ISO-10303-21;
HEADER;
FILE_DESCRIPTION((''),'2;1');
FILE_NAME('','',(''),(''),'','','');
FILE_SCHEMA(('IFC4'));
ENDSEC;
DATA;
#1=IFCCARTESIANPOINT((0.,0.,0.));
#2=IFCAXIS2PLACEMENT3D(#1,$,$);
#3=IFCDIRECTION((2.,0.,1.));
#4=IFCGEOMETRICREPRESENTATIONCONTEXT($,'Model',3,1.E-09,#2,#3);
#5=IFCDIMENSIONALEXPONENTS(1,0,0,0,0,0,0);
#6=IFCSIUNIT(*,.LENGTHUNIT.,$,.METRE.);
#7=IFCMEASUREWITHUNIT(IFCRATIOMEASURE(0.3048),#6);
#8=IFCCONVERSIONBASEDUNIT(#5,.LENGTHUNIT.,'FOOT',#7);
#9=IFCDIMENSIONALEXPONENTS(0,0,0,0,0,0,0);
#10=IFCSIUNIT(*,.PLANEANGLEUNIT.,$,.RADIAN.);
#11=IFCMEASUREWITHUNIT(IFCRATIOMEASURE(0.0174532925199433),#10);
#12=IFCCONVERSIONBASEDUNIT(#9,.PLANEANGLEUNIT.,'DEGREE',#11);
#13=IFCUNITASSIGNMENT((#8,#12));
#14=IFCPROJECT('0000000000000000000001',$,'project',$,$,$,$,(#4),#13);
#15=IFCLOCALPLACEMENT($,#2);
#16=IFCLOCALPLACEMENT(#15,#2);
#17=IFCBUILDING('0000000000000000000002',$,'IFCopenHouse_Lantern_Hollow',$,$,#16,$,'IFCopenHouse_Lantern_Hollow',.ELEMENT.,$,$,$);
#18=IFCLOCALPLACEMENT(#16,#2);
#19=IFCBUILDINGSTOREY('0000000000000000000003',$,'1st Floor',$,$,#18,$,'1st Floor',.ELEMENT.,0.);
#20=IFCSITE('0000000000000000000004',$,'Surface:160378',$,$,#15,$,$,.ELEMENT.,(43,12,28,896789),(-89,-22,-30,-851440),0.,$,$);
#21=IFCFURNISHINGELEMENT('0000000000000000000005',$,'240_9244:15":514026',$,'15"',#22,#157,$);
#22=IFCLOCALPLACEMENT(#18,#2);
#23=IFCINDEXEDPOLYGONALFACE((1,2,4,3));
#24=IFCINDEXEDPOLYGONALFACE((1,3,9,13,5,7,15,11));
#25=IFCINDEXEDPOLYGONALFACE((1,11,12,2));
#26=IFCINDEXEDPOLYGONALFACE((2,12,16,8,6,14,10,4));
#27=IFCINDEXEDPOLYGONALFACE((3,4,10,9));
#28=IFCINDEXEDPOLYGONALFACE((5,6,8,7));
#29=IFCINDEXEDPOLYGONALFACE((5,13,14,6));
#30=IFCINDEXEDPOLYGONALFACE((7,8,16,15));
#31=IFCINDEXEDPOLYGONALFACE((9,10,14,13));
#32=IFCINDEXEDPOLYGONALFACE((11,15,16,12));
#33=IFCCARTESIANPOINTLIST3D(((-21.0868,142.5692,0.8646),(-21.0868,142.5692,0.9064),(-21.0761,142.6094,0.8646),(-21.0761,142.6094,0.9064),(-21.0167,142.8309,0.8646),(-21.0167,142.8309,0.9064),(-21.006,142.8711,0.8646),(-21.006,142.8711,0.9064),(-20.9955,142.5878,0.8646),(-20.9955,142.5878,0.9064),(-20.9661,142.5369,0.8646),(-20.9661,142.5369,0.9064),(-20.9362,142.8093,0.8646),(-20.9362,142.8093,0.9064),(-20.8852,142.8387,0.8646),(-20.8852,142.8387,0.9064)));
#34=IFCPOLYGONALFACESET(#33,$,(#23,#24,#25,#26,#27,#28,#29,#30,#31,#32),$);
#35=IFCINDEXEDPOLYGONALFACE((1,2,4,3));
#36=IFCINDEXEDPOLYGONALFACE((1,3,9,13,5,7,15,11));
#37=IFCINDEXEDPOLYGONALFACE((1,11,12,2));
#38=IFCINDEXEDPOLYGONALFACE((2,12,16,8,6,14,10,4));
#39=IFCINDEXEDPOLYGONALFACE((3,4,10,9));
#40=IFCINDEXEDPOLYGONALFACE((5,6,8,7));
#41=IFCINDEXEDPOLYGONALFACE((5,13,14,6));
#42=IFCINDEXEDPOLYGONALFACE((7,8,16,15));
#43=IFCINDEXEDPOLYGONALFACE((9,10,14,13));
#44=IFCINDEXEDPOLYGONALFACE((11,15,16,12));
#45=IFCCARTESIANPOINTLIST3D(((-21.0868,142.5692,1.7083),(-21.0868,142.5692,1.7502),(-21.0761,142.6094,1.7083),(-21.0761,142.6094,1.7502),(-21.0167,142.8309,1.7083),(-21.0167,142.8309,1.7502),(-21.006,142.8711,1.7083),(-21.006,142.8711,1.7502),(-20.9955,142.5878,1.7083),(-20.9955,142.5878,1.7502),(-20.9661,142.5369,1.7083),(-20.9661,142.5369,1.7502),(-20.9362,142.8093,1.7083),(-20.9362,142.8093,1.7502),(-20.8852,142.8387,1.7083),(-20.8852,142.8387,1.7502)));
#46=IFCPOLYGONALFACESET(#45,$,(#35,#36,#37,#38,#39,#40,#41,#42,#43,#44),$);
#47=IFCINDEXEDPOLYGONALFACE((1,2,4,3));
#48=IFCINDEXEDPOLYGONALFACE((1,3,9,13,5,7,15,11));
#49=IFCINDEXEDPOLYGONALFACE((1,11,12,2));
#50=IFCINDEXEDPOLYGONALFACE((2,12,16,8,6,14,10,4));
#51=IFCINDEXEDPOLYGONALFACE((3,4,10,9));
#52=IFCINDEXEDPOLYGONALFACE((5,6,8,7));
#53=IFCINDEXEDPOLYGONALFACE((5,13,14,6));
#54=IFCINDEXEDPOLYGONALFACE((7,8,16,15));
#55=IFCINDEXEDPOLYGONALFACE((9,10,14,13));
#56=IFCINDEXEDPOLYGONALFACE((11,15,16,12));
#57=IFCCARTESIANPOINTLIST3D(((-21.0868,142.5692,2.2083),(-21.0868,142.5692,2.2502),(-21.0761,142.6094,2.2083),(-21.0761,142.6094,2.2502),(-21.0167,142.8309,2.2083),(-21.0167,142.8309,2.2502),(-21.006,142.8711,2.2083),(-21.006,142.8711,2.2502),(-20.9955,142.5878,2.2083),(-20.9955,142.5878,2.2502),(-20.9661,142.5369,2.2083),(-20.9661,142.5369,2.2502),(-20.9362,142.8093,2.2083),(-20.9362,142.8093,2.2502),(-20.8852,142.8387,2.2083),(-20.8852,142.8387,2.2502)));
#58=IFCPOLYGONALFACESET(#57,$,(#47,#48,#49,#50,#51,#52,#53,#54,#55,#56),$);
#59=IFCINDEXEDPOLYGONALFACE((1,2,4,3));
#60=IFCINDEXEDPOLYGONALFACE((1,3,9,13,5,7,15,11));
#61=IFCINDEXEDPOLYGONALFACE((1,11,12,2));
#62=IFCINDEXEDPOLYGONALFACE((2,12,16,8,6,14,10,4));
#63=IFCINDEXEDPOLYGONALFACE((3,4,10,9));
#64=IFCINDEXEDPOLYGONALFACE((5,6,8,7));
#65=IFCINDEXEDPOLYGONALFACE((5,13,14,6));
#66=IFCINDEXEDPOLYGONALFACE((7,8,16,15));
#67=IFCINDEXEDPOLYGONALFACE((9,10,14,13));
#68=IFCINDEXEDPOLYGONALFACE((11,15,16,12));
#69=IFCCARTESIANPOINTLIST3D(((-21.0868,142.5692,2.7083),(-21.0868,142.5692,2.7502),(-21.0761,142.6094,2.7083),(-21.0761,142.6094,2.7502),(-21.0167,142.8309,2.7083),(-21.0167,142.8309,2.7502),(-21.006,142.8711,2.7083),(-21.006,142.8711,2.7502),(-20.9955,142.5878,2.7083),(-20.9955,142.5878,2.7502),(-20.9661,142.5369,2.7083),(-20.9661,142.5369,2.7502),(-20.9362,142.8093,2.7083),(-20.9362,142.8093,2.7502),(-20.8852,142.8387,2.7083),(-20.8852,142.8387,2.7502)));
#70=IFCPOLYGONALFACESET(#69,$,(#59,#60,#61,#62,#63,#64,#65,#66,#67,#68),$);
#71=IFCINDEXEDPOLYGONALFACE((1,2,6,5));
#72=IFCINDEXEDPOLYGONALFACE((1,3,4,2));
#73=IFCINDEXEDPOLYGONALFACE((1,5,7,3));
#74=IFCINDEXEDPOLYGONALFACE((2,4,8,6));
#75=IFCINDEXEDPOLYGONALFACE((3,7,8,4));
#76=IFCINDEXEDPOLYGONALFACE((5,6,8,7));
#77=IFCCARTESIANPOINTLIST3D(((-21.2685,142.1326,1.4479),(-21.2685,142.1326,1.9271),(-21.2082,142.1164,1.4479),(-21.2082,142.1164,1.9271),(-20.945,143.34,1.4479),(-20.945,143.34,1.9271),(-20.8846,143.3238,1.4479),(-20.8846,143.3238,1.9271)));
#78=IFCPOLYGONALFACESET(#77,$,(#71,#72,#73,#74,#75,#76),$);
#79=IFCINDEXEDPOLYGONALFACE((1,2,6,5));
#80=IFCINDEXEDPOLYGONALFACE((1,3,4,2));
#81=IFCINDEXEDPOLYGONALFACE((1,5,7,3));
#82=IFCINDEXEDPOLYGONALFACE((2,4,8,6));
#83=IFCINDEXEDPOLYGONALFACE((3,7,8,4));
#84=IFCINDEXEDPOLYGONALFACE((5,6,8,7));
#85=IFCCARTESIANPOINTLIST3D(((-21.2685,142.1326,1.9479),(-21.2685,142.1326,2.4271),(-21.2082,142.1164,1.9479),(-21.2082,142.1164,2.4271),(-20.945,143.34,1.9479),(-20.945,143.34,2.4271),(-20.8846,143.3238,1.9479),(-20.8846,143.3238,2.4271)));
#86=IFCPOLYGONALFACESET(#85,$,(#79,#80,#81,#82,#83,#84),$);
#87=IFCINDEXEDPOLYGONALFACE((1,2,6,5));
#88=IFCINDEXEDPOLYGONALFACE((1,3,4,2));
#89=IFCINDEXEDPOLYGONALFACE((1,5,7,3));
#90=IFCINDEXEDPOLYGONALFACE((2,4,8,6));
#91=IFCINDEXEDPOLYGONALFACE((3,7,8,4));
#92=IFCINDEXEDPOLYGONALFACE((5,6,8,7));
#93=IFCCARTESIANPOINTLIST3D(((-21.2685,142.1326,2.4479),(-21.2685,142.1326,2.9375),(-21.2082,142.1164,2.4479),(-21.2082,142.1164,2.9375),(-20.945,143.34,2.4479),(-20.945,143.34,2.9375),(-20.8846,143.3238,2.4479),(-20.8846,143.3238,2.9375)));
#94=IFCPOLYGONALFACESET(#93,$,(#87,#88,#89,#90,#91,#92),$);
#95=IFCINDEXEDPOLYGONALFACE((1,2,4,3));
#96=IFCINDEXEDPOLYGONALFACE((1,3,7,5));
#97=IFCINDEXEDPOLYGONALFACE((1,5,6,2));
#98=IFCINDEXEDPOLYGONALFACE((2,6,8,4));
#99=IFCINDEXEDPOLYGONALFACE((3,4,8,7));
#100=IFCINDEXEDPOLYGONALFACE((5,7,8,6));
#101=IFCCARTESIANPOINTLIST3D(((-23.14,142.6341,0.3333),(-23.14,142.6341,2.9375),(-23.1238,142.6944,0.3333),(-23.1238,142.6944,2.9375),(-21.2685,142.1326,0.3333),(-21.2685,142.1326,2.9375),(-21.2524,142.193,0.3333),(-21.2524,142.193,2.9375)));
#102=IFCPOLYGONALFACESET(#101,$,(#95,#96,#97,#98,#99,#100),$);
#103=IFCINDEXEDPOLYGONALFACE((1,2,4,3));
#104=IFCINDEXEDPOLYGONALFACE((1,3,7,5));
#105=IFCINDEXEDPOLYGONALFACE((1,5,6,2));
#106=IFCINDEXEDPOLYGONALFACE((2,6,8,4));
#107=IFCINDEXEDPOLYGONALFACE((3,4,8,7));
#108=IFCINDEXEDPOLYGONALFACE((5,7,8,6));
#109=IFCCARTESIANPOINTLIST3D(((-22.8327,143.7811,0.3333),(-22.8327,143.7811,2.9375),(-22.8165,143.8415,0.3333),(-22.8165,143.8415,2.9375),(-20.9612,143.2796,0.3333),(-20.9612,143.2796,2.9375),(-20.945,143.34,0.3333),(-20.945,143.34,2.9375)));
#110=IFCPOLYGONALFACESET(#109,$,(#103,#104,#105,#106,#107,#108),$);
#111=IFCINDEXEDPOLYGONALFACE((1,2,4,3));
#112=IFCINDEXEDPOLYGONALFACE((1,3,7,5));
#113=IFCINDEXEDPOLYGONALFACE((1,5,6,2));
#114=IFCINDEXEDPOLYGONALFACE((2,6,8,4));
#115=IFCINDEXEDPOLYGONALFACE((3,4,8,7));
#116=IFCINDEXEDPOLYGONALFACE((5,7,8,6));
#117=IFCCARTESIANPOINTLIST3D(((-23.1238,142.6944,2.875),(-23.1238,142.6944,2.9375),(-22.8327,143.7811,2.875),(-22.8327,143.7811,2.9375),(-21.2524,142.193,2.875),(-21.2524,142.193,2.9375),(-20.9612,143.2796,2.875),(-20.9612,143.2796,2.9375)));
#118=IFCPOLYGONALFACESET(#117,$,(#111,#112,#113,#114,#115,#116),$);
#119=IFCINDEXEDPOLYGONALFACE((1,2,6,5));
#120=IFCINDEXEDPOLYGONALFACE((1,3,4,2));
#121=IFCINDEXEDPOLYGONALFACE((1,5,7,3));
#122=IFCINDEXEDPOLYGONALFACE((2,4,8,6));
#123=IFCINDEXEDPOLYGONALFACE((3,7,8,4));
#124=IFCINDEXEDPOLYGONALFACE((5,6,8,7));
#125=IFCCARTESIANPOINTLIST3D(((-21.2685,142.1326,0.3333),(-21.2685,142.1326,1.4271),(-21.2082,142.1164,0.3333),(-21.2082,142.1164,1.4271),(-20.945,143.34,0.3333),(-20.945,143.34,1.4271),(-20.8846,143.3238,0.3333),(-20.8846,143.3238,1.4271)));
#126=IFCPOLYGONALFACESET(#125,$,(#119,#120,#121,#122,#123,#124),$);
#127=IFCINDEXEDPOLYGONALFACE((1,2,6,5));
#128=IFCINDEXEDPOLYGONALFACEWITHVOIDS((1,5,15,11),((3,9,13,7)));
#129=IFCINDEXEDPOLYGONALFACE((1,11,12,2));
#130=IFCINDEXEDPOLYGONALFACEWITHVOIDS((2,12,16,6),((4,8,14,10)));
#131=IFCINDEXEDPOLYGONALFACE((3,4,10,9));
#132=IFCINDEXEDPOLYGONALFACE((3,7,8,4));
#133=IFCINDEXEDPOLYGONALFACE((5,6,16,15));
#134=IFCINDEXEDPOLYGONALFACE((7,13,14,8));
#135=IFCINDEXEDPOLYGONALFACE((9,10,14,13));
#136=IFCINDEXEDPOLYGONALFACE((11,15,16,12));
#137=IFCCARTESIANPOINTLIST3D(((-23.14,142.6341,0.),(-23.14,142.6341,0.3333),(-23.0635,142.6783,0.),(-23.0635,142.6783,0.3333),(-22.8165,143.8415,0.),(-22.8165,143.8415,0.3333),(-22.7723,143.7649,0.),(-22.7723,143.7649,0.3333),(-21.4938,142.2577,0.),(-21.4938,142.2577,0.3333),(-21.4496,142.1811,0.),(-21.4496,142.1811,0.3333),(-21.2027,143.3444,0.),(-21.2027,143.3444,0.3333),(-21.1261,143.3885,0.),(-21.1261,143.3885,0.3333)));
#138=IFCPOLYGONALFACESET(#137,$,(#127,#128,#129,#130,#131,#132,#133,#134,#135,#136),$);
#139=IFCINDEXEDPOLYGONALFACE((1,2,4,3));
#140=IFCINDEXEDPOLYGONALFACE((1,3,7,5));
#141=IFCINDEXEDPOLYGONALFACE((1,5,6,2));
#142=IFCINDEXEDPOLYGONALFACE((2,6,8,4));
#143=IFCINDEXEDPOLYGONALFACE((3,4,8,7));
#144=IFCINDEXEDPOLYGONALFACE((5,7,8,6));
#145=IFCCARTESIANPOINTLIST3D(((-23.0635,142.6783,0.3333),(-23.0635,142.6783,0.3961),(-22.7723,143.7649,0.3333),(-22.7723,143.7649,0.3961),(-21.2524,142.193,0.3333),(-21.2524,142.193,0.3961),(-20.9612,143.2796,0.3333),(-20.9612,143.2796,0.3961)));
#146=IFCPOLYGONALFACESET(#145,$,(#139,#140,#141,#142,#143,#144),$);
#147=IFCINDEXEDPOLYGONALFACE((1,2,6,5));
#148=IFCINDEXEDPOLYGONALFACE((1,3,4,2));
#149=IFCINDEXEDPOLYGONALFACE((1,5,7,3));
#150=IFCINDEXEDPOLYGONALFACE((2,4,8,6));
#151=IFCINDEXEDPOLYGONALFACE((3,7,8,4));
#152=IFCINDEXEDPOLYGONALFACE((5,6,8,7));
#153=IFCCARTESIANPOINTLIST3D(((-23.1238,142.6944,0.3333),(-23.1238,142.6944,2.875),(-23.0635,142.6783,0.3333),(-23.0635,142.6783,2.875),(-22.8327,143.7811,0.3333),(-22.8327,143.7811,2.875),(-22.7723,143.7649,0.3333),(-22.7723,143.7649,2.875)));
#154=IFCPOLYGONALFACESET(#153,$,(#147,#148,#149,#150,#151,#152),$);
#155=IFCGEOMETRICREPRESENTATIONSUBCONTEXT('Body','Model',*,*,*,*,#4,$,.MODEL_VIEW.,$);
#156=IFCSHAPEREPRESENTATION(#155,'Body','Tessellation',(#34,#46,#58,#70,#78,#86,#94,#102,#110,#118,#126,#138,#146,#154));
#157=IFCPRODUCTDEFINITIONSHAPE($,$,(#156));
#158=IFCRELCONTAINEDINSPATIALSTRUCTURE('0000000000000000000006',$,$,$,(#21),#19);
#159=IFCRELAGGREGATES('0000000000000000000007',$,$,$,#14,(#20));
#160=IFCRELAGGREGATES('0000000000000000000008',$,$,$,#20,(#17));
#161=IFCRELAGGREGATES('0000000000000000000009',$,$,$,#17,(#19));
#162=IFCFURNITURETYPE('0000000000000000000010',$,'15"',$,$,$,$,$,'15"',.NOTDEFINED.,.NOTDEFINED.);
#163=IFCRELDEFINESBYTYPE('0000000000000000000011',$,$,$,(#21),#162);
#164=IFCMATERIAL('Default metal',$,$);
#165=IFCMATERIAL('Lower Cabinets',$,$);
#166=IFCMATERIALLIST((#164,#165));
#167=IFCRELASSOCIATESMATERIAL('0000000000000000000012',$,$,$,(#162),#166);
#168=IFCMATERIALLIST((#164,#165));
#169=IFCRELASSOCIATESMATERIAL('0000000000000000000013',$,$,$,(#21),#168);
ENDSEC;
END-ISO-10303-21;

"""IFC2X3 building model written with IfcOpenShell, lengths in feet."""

from ifc_helpers import new_model, entity, si_unit, converted_unit, direction, frame, frame_2d, origin, origin_2d_with_axis, place, context, subcontext, project, spatial, polyline, rectangle, outline, extrude, source, transform, mapped, material, material_list, type_object, type_shapes, element, save


model = new_model("IFC2X3")

# Units and contexts
model_context = context("Model", 3, precision=1e-09, world=origin(), true_north=direction((2.0, 0.0, 1.0)))
body_context = subcontext(model_context, "Body", "Model", "MODEL_VIEW")
ifc_project = project(units=[converted_unit("LENGTHUNIT", "FOOT", entity("IfcRatioMeasure", 0.3048), si_unit("LENGTHUNIT", "METRE"), dimensions=[1, 0, 0, 0, 0, 0, 0]), converted_unit("PLANEANGLEUNIT", "DEGREE", entity("IfcRatioMeasure", 0.0174532925199433), si_unit("PLANEANGLEUNIT", "RADIAN"), dimensions=[0, 0, 0, 0, 0, 0, 0])], contexts=[model_context])

# Site, building, storey
site_placement = place(None, origin())
site = spatial("IfcSite", under=ifc_project, at=site_placement, Name="Surface:160378", CompositionType="ELEMENT", RefLatitude=(43, 12, 28, 896789), RefLongitude=(-89, -22, -30, -851440), RefElevation=0.0)
building_placement = place(site_placement, origin())
building = spatial("IfcBuilding", under=site, at=building_placement, Name="IFCopenHouse_Lantern_Hollow", LongName="IFCopenHouse_Lantern_Hollow", CompositionType="ELEMENT")
storey_placement = place(building_placement, origin())
storey = spatial("IfcBuildingStorey", under=building, at=storey_placement, Name="1st Floor", LongName="1st Floor", CompositionType="ELEMENT", Elevation=0.0)

# Furnishing element
ifc_material_1 = material(Name="Default metal")
ifc_material_2 = material(Name="Lower Cabinets")
ifc_material_list_1 = material_list([ifc_material_1, ifc_material_2])
ifc_material_list_2 = material_list([ifc_material_1, ifc_material_2])
furniture_type_1 = type_object("IfcFurnitureType", Name="15\"", ElementType="15\"", AssemblyPlace="NOTDEFINED", material=ifc_material_list_2)
shared_shape_1 = source(origin(), body_context, "Body", "SweptSolid", [
    extrude(outline(polyline([(-0.0521, -0.1562), (0.0729, -0.1562), (0.0729, 0.1562), (-0.0521, 0.1562), (-0.0521, 0.1146), (0.0313, 0.1146), (0.0313, -0.1146), (-0.0521, -0.1146), (-0.0521, -0.1562)])), frame((0.625, 0.0729, 0.8646), z_axis=(0.0, 0.0, 1.0), x_axis=(0.0, -1.0, 0.0)), (0.0, 0.0, 1.0), 0.0418),
    extrude(outline(polyline([(-0.0521, -0.1562), (0.0729, -0.1562), (0.0729, 0.1562), (-0.0521, 0.1562), (-0.0521, 0.1146), (0.0313, 0.1146), (0.0313, -0.1146), (-0.0521, -0.1146), (-0.0521, -0.1562)])), frame((0.625, 0.0729, 1.7083), z_axis=(0.0, 0.0, 1.0), x_axis=(0.0, -1.0, 0.0)), (0.0, 0.0, 1.0), 0.0418),
    extrude(outline(polyline([(-0.0521, -0.1562), (0.0729, -0.1562), (0.0729, 0.1562), (-0.0521, 0.1562), (-0.0521, 0.1146), (0.0313, 0.1146), (0.0313, -0.1146), (-0.0521, -0.1146), (-0.0521, -0.1562)])), frame((0.625, 0.0729, 2.2083), z_axis=(0.0, 0.0, 1.0), x_axis=(0.0, -1.0, 0.0)), (0.0, 0.0, 1.0), 0.0418),
    extrude(outline(polyline([(-0.0521, -0.1562), (0.0729, -0.1562), (0.0729, 0.1562), (-0.0521, 0.1562), (-0.0521, 0.1146), (0.0313, 0.1146), (0.0313, -0.1146), (-0.0521, -0.1146), (-0.0521, -0.1562)])), frame((0.625, 0.0729, 2.7083), z_axis=(0.0, 0.0, 1.0), x_axis=(0.0, -1.0, 0.0)), (0.0, 0.0, 1.0), 0.0418),
    extrude(rectangle(XDim=0.0625, YDim=1.25, at=frame_2d((0.0, 0.0), x_axis=(1.0, 0.0))), frame((0.625, 0.1562, 1.4479), z_axis=(0.0, 0.0, 1.0), x_axis=(0.0, 1.0, 0.0)), (0.0, 0.0, 1.0), 0.4792),
    extrude(rectangle(XDim=0.0625, YDim=1.25, at=frame_2d((0.0, 0.0), x_axis=(1.0, 0.0))), frame((0.625, 0.1562, 1.9479), z_axis=(0.0, 0.0, 1.0), x_axis=(0.0, 1.0, 0.0)), (0.0, 0.0, 1.0), 0.4792),
    extrude(rectangle(XDim=0.0625, YDim=1.25, at=frame_2d((0.0, 0.0), x_axis=(1.0, 0.0))), frame((0.625, 0.1562, 2.4479), z_axis=(0.0, 0.0, 1.0), x_axis=(0.0, 1.0, 0.0)), (0.0, 0.0, 1.0), 0.4896),
    extrude(rectangle(XDim=0.0625, YDim=1.9375, at=frame_2d((0.0, 0.0), x_axis=(1.0, 0.0))), frame((0.0313, 1.1562, 0.3333)), (0.0, 0.0, 1.0), 2.6042),
    extrude(rectangle(XDim=0.0625, YDim=1.9375, at=frame_2d((0.0, 0.0), x_axis=(1.0, 0.0))), frame((1.2188, 1.1562, 0.3333)), (0.0, 0.0, 1.0), 2.6042),
    extrude(rectangle(XDim=1.125, YDim=1.9375, at=origin_2d_with_axis()), frame((0.625, 1.1562, 2.875), z_axis=(0.0, 0.0, 1.0), x_axis=(-1.0, 0.0, 0.0)), (0.0, 0.0, 1.0), 0.0625),
    extrude(rectangle(XDim=0.0625, YDim=1.25, at=frame_2d((0.0, 0.0), x_axis=(1.0, 0.0))), frame((0.625, 0.1562, 0.3333), z_axis=(0.0, 0.0, 1.0), x_axis=(0.0, 1.0, 0.0)), (0.0, 0.0, 1.0), 1.0937),
    extrude(outline(polyline([(-0.625, -0.875), (0.625, -0.875), (0.625, 0.875), (-0.625, 0.875), (-0.625, -0.875)]), holes=[polyline([(-0.5625, -0.8125), (-0.5625, 0.8125), (0.5625, 0.8125), (0.5625, -0.8125), (-0.5625, -0.8125)])]), frame((0.625, 1.25, 0.0)), (0.0, 0.0, 1.0), 0.3333),
    extrude(rectangle(XDim=1.125, YDim=1.875, at=frame_2d((0.0, 0.0), x_axis=(1.0, 0.0))), frame((0.625, 1.125, 0.3333), z_axis=(0.0, 0.0, 1.0), x_axis=(-1.0, 0.0, 0.0)), (0.0, 0.0, 1.0), 0.0627),
    extrude(rectangle(XDim=0.0625, YDim=1.125, at=origin_2d_with_axis()), frame((0.625, 2.0938, 0.3333), z_axis=(0.0, 0.0, 1.0), x_axis=(0.0, 1.0, 0.0)), (0.0, 0.0, 1.0), 2.5417),
])
type_shapes(furniture_type_1, [shared_shape_1])
furnishing_1_placement = place(storey_placement, frame((-21.0874, 142.0841, 0.0), z_axis=(0.0, 0.0, 1.0), x_axis=(0.258819, 0.965926, 0.0)))
element("IfcFurnishingElement", 1, at=furnishing_1_placement, inside=storey, type_object=furniture_type_1, material=ifc_material_list_1, Name="240_9244:15\":514026", ObjectType="15\"", context=body_context, shape_type="MappedRepresentation", body=[
    mapped(shared_shape_1, transform((0.0, 0.0, 0.0), scale=1.0)),
])

save(model, "model.ifc")
